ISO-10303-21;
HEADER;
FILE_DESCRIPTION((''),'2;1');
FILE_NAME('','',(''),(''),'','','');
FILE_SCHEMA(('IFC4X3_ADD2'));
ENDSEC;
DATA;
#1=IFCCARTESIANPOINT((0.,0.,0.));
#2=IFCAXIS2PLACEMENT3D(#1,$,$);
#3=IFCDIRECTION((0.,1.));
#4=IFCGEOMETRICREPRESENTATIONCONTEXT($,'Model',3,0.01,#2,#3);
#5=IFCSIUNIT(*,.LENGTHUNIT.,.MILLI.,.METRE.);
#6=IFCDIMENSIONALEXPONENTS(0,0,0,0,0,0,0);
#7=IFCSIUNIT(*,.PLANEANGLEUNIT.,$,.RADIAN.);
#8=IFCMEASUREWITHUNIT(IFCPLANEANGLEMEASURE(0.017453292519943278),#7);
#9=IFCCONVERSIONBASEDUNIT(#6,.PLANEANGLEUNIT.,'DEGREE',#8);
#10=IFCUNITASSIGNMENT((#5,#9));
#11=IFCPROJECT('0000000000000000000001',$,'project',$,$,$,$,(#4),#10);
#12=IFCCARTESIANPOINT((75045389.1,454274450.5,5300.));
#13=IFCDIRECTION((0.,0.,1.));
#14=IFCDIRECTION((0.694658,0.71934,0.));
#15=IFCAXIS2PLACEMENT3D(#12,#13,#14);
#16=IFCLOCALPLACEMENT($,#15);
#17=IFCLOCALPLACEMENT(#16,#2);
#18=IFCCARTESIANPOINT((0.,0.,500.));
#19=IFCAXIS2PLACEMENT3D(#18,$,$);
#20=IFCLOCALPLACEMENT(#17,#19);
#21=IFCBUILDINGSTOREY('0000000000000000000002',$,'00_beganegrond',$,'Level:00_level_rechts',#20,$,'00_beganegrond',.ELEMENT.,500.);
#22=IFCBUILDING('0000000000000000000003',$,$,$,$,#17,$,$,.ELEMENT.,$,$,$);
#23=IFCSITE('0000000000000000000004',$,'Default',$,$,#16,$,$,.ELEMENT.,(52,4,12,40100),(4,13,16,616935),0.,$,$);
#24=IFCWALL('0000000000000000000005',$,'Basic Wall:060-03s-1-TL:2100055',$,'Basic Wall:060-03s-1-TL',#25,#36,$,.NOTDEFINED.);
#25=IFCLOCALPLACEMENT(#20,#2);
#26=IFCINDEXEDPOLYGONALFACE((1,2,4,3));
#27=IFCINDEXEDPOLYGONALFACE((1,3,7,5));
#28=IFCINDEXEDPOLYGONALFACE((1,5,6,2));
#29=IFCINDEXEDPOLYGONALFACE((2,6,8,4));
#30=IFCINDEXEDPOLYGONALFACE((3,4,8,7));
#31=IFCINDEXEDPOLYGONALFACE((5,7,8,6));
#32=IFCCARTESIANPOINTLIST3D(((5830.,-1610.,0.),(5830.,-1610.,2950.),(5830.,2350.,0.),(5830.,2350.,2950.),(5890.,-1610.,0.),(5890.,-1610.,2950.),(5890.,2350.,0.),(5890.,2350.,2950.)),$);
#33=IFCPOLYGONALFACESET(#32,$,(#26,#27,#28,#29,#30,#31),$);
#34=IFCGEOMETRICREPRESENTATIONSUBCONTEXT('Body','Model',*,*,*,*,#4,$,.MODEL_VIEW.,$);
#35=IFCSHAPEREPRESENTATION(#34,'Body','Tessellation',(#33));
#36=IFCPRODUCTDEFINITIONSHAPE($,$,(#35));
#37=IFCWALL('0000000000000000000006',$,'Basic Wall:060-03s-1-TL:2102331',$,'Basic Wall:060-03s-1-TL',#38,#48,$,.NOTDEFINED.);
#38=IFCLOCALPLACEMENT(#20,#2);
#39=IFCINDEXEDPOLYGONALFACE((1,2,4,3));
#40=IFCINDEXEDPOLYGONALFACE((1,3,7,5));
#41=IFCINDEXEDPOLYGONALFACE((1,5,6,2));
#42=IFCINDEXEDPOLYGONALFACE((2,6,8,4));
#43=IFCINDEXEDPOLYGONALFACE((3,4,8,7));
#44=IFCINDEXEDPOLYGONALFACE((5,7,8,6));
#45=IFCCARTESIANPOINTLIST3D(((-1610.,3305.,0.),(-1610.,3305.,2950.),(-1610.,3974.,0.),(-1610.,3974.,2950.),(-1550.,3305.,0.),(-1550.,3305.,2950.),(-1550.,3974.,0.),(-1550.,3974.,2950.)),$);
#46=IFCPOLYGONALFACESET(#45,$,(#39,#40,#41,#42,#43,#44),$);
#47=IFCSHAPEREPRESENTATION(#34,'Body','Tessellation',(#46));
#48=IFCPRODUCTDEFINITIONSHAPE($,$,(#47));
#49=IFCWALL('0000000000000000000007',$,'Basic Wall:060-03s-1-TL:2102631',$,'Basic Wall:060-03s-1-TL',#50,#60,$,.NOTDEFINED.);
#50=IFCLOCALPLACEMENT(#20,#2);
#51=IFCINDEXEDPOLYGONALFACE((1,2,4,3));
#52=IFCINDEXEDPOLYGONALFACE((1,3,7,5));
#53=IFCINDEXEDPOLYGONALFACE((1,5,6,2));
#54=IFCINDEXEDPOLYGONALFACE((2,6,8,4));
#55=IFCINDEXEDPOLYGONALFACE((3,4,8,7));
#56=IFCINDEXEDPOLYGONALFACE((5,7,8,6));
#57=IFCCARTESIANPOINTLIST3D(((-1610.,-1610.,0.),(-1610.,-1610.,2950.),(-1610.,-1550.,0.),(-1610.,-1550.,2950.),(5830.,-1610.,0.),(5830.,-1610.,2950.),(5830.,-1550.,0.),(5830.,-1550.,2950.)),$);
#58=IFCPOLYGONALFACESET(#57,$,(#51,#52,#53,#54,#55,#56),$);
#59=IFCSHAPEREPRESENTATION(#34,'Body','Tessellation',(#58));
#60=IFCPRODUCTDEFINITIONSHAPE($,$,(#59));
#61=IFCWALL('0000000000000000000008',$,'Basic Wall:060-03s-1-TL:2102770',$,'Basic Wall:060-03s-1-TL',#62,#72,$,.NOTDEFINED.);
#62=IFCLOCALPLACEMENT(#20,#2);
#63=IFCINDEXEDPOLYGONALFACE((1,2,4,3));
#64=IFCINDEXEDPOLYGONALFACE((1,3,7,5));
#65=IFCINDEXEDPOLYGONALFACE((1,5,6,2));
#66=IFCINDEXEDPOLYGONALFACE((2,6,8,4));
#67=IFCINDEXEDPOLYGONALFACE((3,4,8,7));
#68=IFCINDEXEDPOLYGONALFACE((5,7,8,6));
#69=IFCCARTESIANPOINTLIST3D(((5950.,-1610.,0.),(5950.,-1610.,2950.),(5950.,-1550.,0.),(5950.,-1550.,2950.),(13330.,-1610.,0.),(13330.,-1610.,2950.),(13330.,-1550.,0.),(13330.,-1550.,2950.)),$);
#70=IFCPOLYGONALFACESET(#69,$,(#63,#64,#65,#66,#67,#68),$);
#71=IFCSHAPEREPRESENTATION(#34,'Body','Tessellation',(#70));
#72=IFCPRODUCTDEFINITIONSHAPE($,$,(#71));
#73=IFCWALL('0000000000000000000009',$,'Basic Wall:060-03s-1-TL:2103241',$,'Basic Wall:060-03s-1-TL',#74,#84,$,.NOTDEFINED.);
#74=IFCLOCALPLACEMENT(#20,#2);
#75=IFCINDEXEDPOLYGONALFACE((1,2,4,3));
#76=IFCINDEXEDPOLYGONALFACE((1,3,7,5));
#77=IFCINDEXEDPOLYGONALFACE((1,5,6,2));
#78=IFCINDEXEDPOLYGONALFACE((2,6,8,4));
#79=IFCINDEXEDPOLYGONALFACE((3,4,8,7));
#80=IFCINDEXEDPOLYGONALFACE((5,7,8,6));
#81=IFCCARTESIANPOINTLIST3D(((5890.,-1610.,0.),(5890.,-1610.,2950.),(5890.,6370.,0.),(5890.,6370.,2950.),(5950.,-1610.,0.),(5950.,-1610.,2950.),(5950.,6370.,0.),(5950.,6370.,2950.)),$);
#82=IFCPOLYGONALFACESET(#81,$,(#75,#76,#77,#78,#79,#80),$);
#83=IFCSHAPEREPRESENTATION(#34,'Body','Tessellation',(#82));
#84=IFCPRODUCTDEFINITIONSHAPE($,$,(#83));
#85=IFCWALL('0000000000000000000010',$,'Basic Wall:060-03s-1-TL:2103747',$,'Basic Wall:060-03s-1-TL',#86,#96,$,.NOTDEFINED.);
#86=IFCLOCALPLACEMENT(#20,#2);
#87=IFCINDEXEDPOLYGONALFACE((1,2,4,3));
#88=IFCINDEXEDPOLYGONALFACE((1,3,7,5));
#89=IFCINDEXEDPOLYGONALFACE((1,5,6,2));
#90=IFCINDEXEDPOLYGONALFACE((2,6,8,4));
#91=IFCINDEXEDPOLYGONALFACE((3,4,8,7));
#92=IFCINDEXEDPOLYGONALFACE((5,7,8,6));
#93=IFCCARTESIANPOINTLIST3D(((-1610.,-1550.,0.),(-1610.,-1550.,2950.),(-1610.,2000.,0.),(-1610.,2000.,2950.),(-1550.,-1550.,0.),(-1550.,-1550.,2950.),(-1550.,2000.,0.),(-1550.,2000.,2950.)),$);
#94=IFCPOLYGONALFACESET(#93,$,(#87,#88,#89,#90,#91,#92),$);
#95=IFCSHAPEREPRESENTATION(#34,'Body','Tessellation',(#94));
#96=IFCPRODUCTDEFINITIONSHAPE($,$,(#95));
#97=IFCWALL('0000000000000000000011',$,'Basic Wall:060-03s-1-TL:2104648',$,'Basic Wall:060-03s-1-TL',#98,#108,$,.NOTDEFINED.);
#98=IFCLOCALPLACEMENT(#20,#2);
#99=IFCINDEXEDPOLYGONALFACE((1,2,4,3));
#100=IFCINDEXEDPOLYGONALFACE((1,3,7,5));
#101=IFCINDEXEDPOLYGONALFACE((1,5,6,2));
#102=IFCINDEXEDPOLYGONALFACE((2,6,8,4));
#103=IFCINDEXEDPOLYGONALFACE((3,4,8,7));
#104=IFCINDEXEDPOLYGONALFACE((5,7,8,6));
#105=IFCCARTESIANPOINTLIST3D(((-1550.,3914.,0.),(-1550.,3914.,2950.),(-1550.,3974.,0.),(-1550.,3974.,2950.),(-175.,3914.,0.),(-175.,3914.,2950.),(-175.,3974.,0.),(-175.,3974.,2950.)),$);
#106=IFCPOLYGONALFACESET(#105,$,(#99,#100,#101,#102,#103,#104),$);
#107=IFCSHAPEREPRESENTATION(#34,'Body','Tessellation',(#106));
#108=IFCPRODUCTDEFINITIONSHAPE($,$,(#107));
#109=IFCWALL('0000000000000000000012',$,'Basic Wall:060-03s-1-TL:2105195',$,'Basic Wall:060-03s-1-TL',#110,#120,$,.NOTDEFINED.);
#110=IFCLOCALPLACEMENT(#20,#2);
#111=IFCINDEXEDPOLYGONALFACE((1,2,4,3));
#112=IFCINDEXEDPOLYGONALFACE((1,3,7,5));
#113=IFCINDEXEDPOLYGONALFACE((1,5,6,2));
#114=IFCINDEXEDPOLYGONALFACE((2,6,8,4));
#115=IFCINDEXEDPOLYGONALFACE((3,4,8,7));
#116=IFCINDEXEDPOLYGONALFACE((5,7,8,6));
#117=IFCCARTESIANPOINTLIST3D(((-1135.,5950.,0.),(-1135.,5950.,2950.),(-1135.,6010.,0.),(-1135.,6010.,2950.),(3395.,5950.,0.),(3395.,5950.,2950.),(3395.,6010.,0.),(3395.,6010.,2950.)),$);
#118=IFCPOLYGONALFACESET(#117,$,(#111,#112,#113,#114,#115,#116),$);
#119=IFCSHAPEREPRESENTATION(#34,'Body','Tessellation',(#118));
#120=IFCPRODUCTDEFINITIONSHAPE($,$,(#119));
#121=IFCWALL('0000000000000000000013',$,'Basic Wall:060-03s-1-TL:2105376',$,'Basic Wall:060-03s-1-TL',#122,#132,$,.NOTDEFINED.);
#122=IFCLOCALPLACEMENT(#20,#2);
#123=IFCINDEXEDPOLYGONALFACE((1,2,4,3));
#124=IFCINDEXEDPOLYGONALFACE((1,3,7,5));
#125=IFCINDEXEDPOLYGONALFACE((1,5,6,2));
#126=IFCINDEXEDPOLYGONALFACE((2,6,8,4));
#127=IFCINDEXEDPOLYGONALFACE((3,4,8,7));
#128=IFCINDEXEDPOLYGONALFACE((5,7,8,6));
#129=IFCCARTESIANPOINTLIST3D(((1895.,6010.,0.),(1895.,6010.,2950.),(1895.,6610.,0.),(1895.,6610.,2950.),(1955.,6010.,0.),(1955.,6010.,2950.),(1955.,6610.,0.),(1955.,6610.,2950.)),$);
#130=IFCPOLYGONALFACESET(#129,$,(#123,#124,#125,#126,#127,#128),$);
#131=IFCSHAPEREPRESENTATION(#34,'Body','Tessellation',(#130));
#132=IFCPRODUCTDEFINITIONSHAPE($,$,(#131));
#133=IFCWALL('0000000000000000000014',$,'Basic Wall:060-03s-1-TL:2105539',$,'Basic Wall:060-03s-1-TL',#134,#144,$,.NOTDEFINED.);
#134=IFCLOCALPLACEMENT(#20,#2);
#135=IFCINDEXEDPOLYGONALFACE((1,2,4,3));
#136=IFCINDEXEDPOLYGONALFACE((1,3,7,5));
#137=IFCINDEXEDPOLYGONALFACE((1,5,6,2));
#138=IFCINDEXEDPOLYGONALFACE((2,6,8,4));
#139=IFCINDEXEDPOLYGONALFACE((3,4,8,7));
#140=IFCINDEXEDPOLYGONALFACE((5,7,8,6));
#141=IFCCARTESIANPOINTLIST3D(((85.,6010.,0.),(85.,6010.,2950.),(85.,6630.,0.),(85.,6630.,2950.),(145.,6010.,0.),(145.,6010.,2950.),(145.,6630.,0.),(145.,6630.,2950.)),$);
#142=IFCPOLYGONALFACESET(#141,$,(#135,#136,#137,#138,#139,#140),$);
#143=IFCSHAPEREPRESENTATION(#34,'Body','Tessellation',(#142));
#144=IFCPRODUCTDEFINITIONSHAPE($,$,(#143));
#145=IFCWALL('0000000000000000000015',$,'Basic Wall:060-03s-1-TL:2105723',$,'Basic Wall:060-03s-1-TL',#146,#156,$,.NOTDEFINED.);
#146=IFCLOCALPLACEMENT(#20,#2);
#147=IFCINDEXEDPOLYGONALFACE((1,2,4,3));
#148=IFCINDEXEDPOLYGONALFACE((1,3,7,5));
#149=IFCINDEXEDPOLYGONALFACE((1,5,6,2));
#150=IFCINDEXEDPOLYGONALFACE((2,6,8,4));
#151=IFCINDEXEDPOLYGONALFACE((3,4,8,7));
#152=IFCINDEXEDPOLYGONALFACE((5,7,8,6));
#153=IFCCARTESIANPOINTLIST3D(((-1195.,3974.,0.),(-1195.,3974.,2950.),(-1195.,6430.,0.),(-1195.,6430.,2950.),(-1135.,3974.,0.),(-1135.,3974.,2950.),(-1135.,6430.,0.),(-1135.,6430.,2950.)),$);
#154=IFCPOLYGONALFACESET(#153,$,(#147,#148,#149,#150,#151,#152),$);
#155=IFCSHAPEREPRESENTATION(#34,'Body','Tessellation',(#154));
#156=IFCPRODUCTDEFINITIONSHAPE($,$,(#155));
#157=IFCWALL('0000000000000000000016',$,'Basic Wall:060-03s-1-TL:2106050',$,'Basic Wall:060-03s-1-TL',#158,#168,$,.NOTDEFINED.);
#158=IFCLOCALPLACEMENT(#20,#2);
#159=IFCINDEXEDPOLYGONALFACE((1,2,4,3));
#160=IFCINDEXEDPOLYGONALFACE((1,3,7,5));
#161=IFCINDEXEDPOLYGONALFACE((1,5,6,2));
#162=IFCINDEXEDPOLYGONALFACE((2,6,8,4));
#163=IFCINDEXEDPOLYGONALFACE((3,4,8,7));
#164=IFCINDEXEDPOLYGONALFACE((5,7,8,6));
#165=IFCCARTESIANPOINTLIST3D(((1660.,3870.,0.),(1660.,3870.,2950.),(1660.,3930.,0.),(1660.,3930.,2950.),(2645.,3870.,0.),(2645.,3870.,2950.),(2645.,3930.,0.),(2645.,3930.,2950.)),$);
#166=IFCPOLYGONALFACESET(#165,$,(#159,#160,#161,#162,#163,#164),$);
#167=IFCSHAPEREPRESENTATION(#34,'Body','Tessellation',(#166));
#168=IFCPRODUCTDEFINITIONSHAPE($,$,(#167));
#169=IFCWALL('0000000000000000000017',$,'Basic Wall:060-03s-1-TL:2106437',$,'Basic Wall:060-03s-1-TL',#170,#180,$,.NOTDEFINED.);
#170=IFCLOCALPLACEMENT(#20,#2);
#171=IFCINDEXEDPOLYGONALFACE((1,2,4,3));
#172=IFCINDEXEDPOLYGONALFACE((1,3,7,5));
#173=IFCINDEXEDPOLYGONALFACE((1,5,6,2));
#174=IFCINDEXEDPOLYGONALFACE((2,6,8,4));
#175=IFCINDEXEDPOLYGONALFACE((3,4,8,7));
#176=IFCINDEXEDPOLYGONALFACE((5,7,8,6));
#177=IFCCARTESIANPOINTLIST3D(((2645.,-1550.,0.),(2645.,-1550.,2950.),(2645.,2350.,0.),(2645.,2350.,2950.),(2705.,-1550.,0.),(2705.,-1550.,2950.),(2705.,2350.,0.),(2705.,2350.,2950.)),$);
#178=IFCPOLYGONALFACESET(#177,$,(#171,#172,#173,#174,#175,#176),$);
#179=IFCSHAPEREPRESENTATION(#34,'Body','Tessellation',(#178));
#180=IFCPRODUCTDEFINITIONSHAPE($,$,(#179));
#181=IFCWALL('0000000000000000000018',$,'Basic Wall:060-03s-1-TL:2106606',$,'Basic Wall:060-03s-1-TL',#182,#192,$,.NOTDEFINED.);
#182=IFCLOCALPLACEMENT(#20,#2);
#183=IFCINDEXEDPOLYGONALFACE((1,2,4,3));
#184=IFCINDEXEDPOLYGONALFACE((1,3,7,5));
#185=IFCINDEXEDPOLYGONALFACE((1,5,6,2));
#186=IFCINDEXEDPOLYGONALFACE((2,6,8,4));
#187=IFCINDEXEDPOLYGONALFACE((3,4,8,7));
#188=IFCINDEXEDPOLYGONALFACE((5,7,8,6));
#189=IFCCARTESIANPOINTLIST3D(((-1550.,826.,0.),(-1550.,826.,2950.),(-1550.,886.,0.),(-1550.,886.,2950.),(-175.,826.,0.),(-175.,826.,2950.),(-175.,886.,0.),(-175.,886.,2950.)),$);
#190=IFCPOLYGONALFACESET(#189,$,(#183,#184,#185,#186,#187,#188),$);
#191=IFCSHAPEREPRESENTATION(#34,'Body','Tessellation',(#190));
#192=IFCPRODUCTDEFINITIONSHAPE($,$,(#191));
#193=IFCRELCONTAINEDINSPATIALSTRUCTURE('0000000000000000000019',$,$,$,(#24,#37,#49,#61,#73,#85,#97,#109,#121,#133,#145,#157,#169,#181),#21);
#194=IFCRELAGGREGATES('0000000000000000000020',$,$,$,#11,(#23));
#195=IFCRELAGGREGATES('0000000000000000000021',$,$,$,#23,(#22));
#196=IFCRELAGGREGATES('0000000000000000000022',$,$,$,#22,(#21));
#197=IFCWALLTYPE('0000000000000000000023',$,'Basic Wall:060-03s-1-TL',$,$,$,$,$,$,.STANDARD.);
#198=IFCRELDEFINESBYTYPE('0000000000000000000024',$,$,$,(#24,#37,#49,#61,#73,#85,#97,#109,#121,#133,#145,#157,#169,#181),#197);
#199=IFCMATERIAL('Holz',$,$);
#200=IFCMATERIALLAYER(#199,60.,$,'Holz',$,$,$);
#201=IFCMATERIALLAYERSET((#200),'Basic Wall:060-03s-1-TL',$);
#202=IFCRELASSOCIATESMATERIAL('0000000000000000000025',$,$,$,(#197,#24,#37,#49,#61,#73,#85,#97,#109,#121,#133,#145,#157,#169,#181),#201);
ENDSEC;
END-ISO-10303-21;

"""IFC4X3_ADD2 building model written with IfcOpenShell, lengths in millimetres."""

from ifc_helpers import new_model, entity, si_unit, converted_unit, direction, frame, frame_2d, origin, place, context, subcontext, project, spatial, rectangle, extrude, material, layer, layer_set, type_object, element, save


model = new_model("IFC4X3_ADD2")

# Units and contexts
model_context = context("Model", 3, precision=0.01, world=origin(), true_north=direction((0.0, 1.0)))
body_context = subcontext(model_context, "Body", "Model", "MODEL_VIEW")
ifc_project = project(units=[si_unit("LENGTHUNIT", "METRE", prefix="MILLI"), converted_unit("PLANEANGLEUNIT", "DEGREE", entity("IfcPlaneAngleMeasure", 0.017453292519943278), si_unit("PLANEANGLEUNIT", "RADIAN"), dimensions=[0, 0, 0, 0, 0, 0, 0])], contexts=[model_context])

# Site, building, storey
site_placement = place(None, frame((75045389.1, 454274450.5, 5300.0), z_axis=(0.0, 0.0, 1.0), x_axis=(0.694658, 0.71934, 0.0)))
site = spatial("IfcSite", under=ifc_project, at=site_placement, Name="Default", CompositionType="ELEMENT", RefLatitude=(52, 4, 12, 40100), RefLongitude=(4, 13, 16, 616935), RefElevation=0.0)
building_placement = place(site_placement, origin())
building = spatial("IfcBuilding", under=site, at=building_placement, CompositionType="ELEMENT")
storey_placement = place(building_placement, frame((0.0, 0.0, 500.0)))
storey = spatial("IfcBuildingStorey", under=building, at=storey_placement, Name="00_beganegrond", ObjectType="Level:00_level_rechts", LongName="00_beganegrond", CompositionType="ELEMENT", Elevation=500.0)

# Shared definitions
ifc_material_1 = material(Name="Holz")

# Walls
ifc_layer_1 = layer(ifc_material_1, 60.0, Name="Holz")
ifc_layer_set_1 = layer_set([ifc_layer_1], Name="Basic Wall:060-03s-1-TL")
wall_type = type_object("IfcWallType", Name="Basic Wall:060-03s-1-TL", PredefinedType="STANDARD", material=ifc_layer_set_1)
wall_1_placement = place(storey_placement, frame((5860.0, -1610.0, 0.0), z_axis=(0.0, 0.0, 1.0), x_axis=(0.0, 1.0, 0.0)))
element("IfcWall", 1, at=wall_1_placement, inside=storey, type_object=wall_type, material=ifc_layer_set_1, Name="Basic Wall:060-03s-1-TL:2100055", ObjectType="Basic Wall:060-03s-1-TL", PredefinedType="NOTDEFINED", context=body_context, shape_type="SweptSolid", body=[
    extrude(rectangle(XDim=3960.0, YDim=60.0, at=frame_2d((1980.0, 0.0), x_axis=(-1.0, 0.0))), origin(), (0.0, 0.0, 1.0), 2950.0),
])
wall_2_placement = place(storey_placement, frame((-1580.0, 3305.0, 0.0), z_axis=(0.0, 0.0, 1.0), x_axis=(0.0, 1.0, 0.0)))
element("IfcWall", 2, at=wall_2_placement, inside=storey, type_object=wall_type, material=ifc_layer_set_1, Name="Basic Wall:060-03s-1-TL:2102331", ObjectType="Basic Wall:060-03s-1-TL", PredefinedType="NOTDEFINED", context=body_context, shape_type="SweptSolid", body=[
    extrude(rectangle(XDim=669.0, YDim=60.0, at=frame_2d((334.5, 0.0), x_axis=(-1.0, 0.0))), origin(), (0.0, 0.0, 1.0), 2950.0),
])
wall_3_placement = place(storey_placement, frame((-1610.0, -1580.0, 0.0)))
element("IfcWall", 3, at=wall_3_placement, inside=storey, type_object=wall_type, material=ifc_layer_set_1, Name="Basic Wall:060-03s-1-TL:2102631", ObjectType="Basic Wall:060-03s-1-TL", PredefinedType="NOTDEFINED", context=body_context, shape_type="SweptSolid", body=[
    extrude(rectangle(XDim=7440.0, YDim=60.0, at=frame_2d((3720.0, 0.0), x_axis=(-1.0, 0.0))), origin(), (0.0, 0.0, 1.0), 2950.0),
])
wall_4_placement = place(storey_placement, frame((5950.0, -1580.0, 0.0)))
element("IfcWall", 4, at=wall_4_placement, inside=storey, type_object=wall_type, material=ifc_layer_set_1, Name="Basic Wall:060-03s-1-TL:2102770", ObjectType="Basic Wall:060-03s-1-TL", PredefinedType="NOTDEFINED", context=body_context, shape_type="SweptSolid", body=[
    extrude(rectangle(XDim=7380.0, YDim=60.0, at=frame_2d((3690.0, 0.0), x_axis=(-1.0, 0.0))), origin(), (0.0, 0.0, 1.0), 2950.0),
])
wall_5_placement = place(storey_placement, frame((5920.0, -1610.0, 0.0), z_axis=(0.0, 0.0, 1.0), x_axis=(0.0, 1.0, 0.0)))
element("IfcWall", 5, at=wall_5_placement, inside=storey, type_object=wall_type, material=ifc_layer_set_1, Name="Basic Wall:060-03s-1-TL:2103241", ObjectType="Basic Wall:060-03s-1-TL", PredefinedType="NOTDEFINED", context=body_context, shape_type="SweptSolid", body=[
    extrude(rectangle(XDim=7980.0, YDim=60.0, at=frame_2d((3990.0, 0.0), x_axis=(-1.0, 0.0))), origin(), (0.0, 0.0, 1.0), 2950.0),
])
wall_6_placement = place(storey_placement, frame((-1580.0, -1550.0, 0.0), z_axis=(0.0, 0.0, 1.0), x_axis=(0.0, 1.0, 0.0)))
element("IfcWall", 6, at=wall_6_placement, inside=storey, type_object=wall_type, material=ifc_layer_set_1, Name="Basic Wall:060-03s-1-TL:2103747", ObjectType="Basic Wall:060-03s-1-TL", PredefinedType="NOTDEFINED", context=body_context, shape_type="SweptSolid", body=[
    extrude(rectangle(XDim=3550.0, YDim=60.0, at=frame_2d((1775.0, 0.0), x_axis=(-1.0, 0.0))), origin(), (0.0, 0.0, 1.0), 2950.0),
])
wall_7_placement = place(storey_placement, frame((-1550.0, 3944.0, 0.0)))
element("IfcWall", 7, at=wall_7_placement, inside=storey, type_object=wall_type, material=ifc_layer_set_1, Name="Basic Wall:060-03s-1-TL:2104648", ObjectType="Basic Wall:060-03s-1-TL", PredefinedType="NOTDEFINED", context=body_context, shape_type="SweptSolid", body=[
    extrude(rectangle(XDim=1375.0, YDim=60.0, at=frame_2d((687.5, 0.0), x_axis=(-1.0, 0.0))), origin(), (0.0, 0.0, 1.0), 2950.0),
])
wall_8_placement = place(storey_placement, frame((-1135.0, 5980.0, 0.0)))
element("IfcWall", 8, at=wall_8_placement, inside=storey, type_object=wall_type, material=ifc_layer_set_1, Name="Basic Wall:060-03s-1-TL:2105195", ObjectType="Basic Wall:060-03s-1-TL", PredefinedType="NOTDEFINED", context=body_context, shape_type="SweptSolid", body=[
    extrude(rectangle(XDim=4530.0, YDim=60.0, at=frame_2d((2265.0, 0.0), x_axis=(-1.0, 0.0))), origin(), (0.0, 0.0, 1.0), 2950.0),
])
wall_9_placement = place(storey_placement, frame((1925.0, 6010.0, 0.0), z_axis=(0.0, 0.0, 1.0), x_axis=(0.0, 1.0, 0.0)))
element("IfcWall", 9, at=wall_9_placement, inside=storey, type_object=wall_type, material=ifc_layer_set_1, Name="Basic Wall:060-03s-1-TL:2105376", ObjectType="Basic Wall:060-03s-1-TL", PredefinedType="NOTDEFINED", context=body_context, shape_type="SweptSolid", body=[
    extrude(rectangle(XDim=600.0, YDim=60.0, at=frame_2d((300.0, 0.0), x_axis=(-1.0, 0.0))), origin(), (0.0, 0.0, 1.0), 2950.0),
])
wall_10_placement = place(storey_placement, frame((115.0, 6630.0, 0.0), z_axis=(0.0, 0.0, 1.0), x_axis=(0.0, -1.0, 0.0)))
element("IfcWall", 10, at=wall_10_placement, inside=storey, type_object=wall_type, material=ifc_layer_set_1, Name="Basic Wall:060-03s-1-TL:2105539", ObjectType="Basic Wall:060-03s-1-TL", PredefinedType="NOTDEFINED", context=body_context, shape_type="SweptSolid", body=[
    extrude(rectangle(XDim=620.0, YDim=60.0, at=frame_2d((310.0, 0.0), x_axis=(-1.0, 0.0))), origin(), (0.0, 0.0, 1.0), 2950.0),
])
wall_11_placement = place(storey_placement, frame((-1165.0, 6430.0, 0.0), z_axis=(0.0, 0.0, 1.0), x_axis=(0.0, -1.0, 0.0)))
element("IfcWall", 11, at=wall_11_placement, inside=storey, type_object=wall_type, material=ifc_layer_set_1, Name="Basic Wall:060-03s-1-TL:2105723", ObjectType="Basic Wall:060-03s-1-TL", PredefinedType="NOTDEFINED", context=body_context, shape_type="SweptSolid", body=[
    extrude(rectangle(XDim=2456.0, YDim=60.0, at=frame_2d((1228.0, 0.0), x_axis=(-1.0, 0.0))), origin(), (0.0, 0.0, 1.0), 2950.0),
])
wall_12_placement = place(storey_placement, frame((1660.0, 3900.0, 0.0)))
element("IfcWall", 12, at=wall_12_placement, inside=storey, type_object=wall_type, material=ifc_layer_set_1, Name="Basic Wall:060-03s-1-TL:2106050", ObjectType="Basic Wall:060-03s-1-TL", PredefinedType="NOTDEFINED", context=body_context, shape_type="SweptSolid", body=[
    extrude(rectangle(XDim=985.0, YDim=60.0, at=frame_2d((492.5, 0.0), x_axis=(-1.0, 0.0))), origin(), (0.0, 0.0, 1.0), 2950.0),
])
wall_13_placement = place(storey_placement, frame((2675.0, -1550.0, 0.0), z_axis=(0.0, 0.0, 1.0), x_axis=(0.0, 1.0, 0.0)))
element("IfcWall", 13, at=wall_13_placement, inside=storey, type_object=wall_type, material=ifc_layer_set_1, Name="Basic Wall:060-03s-1-TL:2106437", ObjectType="Basic Wall:060-03s-1-TL", PredefinedType="NOTDEFINED", context=body_context, shape_type="SweptSolid", body=[
    extrude(rectangle(XDim=3900.0, YDim=60.0, at=frame_2d((1950.0, 0.0), x_axis=(-1.0, 0.0))), origin(), (0.0, 0.0, 1.0), 2950.0),
])
wall_14_placement = place(storey_placement, frame((-1550.0, 856.0, 0.0)))
element("IfcWall", 14, at=wall_14_placement, inside=storey, type_object=wall_type, material=ifc_layer_set_1, Name="Basic Wall:060-03s-1-TL:2106606", ObjectType="Basic Wall:060-03s-1-TL", PredefinedType="NOTDEFINED", context=body_context, shape_type="SweptSolid", body=[
    extrude(rectangle(XDim=1375.0, YDim=60.0, at=frame_2d((687.5, 0.0), x_axis=(-1.0, 0.0))), origin(), (0.0, 0.0, 1.0), 2950.0),
])

save(model, "model.ifc")
